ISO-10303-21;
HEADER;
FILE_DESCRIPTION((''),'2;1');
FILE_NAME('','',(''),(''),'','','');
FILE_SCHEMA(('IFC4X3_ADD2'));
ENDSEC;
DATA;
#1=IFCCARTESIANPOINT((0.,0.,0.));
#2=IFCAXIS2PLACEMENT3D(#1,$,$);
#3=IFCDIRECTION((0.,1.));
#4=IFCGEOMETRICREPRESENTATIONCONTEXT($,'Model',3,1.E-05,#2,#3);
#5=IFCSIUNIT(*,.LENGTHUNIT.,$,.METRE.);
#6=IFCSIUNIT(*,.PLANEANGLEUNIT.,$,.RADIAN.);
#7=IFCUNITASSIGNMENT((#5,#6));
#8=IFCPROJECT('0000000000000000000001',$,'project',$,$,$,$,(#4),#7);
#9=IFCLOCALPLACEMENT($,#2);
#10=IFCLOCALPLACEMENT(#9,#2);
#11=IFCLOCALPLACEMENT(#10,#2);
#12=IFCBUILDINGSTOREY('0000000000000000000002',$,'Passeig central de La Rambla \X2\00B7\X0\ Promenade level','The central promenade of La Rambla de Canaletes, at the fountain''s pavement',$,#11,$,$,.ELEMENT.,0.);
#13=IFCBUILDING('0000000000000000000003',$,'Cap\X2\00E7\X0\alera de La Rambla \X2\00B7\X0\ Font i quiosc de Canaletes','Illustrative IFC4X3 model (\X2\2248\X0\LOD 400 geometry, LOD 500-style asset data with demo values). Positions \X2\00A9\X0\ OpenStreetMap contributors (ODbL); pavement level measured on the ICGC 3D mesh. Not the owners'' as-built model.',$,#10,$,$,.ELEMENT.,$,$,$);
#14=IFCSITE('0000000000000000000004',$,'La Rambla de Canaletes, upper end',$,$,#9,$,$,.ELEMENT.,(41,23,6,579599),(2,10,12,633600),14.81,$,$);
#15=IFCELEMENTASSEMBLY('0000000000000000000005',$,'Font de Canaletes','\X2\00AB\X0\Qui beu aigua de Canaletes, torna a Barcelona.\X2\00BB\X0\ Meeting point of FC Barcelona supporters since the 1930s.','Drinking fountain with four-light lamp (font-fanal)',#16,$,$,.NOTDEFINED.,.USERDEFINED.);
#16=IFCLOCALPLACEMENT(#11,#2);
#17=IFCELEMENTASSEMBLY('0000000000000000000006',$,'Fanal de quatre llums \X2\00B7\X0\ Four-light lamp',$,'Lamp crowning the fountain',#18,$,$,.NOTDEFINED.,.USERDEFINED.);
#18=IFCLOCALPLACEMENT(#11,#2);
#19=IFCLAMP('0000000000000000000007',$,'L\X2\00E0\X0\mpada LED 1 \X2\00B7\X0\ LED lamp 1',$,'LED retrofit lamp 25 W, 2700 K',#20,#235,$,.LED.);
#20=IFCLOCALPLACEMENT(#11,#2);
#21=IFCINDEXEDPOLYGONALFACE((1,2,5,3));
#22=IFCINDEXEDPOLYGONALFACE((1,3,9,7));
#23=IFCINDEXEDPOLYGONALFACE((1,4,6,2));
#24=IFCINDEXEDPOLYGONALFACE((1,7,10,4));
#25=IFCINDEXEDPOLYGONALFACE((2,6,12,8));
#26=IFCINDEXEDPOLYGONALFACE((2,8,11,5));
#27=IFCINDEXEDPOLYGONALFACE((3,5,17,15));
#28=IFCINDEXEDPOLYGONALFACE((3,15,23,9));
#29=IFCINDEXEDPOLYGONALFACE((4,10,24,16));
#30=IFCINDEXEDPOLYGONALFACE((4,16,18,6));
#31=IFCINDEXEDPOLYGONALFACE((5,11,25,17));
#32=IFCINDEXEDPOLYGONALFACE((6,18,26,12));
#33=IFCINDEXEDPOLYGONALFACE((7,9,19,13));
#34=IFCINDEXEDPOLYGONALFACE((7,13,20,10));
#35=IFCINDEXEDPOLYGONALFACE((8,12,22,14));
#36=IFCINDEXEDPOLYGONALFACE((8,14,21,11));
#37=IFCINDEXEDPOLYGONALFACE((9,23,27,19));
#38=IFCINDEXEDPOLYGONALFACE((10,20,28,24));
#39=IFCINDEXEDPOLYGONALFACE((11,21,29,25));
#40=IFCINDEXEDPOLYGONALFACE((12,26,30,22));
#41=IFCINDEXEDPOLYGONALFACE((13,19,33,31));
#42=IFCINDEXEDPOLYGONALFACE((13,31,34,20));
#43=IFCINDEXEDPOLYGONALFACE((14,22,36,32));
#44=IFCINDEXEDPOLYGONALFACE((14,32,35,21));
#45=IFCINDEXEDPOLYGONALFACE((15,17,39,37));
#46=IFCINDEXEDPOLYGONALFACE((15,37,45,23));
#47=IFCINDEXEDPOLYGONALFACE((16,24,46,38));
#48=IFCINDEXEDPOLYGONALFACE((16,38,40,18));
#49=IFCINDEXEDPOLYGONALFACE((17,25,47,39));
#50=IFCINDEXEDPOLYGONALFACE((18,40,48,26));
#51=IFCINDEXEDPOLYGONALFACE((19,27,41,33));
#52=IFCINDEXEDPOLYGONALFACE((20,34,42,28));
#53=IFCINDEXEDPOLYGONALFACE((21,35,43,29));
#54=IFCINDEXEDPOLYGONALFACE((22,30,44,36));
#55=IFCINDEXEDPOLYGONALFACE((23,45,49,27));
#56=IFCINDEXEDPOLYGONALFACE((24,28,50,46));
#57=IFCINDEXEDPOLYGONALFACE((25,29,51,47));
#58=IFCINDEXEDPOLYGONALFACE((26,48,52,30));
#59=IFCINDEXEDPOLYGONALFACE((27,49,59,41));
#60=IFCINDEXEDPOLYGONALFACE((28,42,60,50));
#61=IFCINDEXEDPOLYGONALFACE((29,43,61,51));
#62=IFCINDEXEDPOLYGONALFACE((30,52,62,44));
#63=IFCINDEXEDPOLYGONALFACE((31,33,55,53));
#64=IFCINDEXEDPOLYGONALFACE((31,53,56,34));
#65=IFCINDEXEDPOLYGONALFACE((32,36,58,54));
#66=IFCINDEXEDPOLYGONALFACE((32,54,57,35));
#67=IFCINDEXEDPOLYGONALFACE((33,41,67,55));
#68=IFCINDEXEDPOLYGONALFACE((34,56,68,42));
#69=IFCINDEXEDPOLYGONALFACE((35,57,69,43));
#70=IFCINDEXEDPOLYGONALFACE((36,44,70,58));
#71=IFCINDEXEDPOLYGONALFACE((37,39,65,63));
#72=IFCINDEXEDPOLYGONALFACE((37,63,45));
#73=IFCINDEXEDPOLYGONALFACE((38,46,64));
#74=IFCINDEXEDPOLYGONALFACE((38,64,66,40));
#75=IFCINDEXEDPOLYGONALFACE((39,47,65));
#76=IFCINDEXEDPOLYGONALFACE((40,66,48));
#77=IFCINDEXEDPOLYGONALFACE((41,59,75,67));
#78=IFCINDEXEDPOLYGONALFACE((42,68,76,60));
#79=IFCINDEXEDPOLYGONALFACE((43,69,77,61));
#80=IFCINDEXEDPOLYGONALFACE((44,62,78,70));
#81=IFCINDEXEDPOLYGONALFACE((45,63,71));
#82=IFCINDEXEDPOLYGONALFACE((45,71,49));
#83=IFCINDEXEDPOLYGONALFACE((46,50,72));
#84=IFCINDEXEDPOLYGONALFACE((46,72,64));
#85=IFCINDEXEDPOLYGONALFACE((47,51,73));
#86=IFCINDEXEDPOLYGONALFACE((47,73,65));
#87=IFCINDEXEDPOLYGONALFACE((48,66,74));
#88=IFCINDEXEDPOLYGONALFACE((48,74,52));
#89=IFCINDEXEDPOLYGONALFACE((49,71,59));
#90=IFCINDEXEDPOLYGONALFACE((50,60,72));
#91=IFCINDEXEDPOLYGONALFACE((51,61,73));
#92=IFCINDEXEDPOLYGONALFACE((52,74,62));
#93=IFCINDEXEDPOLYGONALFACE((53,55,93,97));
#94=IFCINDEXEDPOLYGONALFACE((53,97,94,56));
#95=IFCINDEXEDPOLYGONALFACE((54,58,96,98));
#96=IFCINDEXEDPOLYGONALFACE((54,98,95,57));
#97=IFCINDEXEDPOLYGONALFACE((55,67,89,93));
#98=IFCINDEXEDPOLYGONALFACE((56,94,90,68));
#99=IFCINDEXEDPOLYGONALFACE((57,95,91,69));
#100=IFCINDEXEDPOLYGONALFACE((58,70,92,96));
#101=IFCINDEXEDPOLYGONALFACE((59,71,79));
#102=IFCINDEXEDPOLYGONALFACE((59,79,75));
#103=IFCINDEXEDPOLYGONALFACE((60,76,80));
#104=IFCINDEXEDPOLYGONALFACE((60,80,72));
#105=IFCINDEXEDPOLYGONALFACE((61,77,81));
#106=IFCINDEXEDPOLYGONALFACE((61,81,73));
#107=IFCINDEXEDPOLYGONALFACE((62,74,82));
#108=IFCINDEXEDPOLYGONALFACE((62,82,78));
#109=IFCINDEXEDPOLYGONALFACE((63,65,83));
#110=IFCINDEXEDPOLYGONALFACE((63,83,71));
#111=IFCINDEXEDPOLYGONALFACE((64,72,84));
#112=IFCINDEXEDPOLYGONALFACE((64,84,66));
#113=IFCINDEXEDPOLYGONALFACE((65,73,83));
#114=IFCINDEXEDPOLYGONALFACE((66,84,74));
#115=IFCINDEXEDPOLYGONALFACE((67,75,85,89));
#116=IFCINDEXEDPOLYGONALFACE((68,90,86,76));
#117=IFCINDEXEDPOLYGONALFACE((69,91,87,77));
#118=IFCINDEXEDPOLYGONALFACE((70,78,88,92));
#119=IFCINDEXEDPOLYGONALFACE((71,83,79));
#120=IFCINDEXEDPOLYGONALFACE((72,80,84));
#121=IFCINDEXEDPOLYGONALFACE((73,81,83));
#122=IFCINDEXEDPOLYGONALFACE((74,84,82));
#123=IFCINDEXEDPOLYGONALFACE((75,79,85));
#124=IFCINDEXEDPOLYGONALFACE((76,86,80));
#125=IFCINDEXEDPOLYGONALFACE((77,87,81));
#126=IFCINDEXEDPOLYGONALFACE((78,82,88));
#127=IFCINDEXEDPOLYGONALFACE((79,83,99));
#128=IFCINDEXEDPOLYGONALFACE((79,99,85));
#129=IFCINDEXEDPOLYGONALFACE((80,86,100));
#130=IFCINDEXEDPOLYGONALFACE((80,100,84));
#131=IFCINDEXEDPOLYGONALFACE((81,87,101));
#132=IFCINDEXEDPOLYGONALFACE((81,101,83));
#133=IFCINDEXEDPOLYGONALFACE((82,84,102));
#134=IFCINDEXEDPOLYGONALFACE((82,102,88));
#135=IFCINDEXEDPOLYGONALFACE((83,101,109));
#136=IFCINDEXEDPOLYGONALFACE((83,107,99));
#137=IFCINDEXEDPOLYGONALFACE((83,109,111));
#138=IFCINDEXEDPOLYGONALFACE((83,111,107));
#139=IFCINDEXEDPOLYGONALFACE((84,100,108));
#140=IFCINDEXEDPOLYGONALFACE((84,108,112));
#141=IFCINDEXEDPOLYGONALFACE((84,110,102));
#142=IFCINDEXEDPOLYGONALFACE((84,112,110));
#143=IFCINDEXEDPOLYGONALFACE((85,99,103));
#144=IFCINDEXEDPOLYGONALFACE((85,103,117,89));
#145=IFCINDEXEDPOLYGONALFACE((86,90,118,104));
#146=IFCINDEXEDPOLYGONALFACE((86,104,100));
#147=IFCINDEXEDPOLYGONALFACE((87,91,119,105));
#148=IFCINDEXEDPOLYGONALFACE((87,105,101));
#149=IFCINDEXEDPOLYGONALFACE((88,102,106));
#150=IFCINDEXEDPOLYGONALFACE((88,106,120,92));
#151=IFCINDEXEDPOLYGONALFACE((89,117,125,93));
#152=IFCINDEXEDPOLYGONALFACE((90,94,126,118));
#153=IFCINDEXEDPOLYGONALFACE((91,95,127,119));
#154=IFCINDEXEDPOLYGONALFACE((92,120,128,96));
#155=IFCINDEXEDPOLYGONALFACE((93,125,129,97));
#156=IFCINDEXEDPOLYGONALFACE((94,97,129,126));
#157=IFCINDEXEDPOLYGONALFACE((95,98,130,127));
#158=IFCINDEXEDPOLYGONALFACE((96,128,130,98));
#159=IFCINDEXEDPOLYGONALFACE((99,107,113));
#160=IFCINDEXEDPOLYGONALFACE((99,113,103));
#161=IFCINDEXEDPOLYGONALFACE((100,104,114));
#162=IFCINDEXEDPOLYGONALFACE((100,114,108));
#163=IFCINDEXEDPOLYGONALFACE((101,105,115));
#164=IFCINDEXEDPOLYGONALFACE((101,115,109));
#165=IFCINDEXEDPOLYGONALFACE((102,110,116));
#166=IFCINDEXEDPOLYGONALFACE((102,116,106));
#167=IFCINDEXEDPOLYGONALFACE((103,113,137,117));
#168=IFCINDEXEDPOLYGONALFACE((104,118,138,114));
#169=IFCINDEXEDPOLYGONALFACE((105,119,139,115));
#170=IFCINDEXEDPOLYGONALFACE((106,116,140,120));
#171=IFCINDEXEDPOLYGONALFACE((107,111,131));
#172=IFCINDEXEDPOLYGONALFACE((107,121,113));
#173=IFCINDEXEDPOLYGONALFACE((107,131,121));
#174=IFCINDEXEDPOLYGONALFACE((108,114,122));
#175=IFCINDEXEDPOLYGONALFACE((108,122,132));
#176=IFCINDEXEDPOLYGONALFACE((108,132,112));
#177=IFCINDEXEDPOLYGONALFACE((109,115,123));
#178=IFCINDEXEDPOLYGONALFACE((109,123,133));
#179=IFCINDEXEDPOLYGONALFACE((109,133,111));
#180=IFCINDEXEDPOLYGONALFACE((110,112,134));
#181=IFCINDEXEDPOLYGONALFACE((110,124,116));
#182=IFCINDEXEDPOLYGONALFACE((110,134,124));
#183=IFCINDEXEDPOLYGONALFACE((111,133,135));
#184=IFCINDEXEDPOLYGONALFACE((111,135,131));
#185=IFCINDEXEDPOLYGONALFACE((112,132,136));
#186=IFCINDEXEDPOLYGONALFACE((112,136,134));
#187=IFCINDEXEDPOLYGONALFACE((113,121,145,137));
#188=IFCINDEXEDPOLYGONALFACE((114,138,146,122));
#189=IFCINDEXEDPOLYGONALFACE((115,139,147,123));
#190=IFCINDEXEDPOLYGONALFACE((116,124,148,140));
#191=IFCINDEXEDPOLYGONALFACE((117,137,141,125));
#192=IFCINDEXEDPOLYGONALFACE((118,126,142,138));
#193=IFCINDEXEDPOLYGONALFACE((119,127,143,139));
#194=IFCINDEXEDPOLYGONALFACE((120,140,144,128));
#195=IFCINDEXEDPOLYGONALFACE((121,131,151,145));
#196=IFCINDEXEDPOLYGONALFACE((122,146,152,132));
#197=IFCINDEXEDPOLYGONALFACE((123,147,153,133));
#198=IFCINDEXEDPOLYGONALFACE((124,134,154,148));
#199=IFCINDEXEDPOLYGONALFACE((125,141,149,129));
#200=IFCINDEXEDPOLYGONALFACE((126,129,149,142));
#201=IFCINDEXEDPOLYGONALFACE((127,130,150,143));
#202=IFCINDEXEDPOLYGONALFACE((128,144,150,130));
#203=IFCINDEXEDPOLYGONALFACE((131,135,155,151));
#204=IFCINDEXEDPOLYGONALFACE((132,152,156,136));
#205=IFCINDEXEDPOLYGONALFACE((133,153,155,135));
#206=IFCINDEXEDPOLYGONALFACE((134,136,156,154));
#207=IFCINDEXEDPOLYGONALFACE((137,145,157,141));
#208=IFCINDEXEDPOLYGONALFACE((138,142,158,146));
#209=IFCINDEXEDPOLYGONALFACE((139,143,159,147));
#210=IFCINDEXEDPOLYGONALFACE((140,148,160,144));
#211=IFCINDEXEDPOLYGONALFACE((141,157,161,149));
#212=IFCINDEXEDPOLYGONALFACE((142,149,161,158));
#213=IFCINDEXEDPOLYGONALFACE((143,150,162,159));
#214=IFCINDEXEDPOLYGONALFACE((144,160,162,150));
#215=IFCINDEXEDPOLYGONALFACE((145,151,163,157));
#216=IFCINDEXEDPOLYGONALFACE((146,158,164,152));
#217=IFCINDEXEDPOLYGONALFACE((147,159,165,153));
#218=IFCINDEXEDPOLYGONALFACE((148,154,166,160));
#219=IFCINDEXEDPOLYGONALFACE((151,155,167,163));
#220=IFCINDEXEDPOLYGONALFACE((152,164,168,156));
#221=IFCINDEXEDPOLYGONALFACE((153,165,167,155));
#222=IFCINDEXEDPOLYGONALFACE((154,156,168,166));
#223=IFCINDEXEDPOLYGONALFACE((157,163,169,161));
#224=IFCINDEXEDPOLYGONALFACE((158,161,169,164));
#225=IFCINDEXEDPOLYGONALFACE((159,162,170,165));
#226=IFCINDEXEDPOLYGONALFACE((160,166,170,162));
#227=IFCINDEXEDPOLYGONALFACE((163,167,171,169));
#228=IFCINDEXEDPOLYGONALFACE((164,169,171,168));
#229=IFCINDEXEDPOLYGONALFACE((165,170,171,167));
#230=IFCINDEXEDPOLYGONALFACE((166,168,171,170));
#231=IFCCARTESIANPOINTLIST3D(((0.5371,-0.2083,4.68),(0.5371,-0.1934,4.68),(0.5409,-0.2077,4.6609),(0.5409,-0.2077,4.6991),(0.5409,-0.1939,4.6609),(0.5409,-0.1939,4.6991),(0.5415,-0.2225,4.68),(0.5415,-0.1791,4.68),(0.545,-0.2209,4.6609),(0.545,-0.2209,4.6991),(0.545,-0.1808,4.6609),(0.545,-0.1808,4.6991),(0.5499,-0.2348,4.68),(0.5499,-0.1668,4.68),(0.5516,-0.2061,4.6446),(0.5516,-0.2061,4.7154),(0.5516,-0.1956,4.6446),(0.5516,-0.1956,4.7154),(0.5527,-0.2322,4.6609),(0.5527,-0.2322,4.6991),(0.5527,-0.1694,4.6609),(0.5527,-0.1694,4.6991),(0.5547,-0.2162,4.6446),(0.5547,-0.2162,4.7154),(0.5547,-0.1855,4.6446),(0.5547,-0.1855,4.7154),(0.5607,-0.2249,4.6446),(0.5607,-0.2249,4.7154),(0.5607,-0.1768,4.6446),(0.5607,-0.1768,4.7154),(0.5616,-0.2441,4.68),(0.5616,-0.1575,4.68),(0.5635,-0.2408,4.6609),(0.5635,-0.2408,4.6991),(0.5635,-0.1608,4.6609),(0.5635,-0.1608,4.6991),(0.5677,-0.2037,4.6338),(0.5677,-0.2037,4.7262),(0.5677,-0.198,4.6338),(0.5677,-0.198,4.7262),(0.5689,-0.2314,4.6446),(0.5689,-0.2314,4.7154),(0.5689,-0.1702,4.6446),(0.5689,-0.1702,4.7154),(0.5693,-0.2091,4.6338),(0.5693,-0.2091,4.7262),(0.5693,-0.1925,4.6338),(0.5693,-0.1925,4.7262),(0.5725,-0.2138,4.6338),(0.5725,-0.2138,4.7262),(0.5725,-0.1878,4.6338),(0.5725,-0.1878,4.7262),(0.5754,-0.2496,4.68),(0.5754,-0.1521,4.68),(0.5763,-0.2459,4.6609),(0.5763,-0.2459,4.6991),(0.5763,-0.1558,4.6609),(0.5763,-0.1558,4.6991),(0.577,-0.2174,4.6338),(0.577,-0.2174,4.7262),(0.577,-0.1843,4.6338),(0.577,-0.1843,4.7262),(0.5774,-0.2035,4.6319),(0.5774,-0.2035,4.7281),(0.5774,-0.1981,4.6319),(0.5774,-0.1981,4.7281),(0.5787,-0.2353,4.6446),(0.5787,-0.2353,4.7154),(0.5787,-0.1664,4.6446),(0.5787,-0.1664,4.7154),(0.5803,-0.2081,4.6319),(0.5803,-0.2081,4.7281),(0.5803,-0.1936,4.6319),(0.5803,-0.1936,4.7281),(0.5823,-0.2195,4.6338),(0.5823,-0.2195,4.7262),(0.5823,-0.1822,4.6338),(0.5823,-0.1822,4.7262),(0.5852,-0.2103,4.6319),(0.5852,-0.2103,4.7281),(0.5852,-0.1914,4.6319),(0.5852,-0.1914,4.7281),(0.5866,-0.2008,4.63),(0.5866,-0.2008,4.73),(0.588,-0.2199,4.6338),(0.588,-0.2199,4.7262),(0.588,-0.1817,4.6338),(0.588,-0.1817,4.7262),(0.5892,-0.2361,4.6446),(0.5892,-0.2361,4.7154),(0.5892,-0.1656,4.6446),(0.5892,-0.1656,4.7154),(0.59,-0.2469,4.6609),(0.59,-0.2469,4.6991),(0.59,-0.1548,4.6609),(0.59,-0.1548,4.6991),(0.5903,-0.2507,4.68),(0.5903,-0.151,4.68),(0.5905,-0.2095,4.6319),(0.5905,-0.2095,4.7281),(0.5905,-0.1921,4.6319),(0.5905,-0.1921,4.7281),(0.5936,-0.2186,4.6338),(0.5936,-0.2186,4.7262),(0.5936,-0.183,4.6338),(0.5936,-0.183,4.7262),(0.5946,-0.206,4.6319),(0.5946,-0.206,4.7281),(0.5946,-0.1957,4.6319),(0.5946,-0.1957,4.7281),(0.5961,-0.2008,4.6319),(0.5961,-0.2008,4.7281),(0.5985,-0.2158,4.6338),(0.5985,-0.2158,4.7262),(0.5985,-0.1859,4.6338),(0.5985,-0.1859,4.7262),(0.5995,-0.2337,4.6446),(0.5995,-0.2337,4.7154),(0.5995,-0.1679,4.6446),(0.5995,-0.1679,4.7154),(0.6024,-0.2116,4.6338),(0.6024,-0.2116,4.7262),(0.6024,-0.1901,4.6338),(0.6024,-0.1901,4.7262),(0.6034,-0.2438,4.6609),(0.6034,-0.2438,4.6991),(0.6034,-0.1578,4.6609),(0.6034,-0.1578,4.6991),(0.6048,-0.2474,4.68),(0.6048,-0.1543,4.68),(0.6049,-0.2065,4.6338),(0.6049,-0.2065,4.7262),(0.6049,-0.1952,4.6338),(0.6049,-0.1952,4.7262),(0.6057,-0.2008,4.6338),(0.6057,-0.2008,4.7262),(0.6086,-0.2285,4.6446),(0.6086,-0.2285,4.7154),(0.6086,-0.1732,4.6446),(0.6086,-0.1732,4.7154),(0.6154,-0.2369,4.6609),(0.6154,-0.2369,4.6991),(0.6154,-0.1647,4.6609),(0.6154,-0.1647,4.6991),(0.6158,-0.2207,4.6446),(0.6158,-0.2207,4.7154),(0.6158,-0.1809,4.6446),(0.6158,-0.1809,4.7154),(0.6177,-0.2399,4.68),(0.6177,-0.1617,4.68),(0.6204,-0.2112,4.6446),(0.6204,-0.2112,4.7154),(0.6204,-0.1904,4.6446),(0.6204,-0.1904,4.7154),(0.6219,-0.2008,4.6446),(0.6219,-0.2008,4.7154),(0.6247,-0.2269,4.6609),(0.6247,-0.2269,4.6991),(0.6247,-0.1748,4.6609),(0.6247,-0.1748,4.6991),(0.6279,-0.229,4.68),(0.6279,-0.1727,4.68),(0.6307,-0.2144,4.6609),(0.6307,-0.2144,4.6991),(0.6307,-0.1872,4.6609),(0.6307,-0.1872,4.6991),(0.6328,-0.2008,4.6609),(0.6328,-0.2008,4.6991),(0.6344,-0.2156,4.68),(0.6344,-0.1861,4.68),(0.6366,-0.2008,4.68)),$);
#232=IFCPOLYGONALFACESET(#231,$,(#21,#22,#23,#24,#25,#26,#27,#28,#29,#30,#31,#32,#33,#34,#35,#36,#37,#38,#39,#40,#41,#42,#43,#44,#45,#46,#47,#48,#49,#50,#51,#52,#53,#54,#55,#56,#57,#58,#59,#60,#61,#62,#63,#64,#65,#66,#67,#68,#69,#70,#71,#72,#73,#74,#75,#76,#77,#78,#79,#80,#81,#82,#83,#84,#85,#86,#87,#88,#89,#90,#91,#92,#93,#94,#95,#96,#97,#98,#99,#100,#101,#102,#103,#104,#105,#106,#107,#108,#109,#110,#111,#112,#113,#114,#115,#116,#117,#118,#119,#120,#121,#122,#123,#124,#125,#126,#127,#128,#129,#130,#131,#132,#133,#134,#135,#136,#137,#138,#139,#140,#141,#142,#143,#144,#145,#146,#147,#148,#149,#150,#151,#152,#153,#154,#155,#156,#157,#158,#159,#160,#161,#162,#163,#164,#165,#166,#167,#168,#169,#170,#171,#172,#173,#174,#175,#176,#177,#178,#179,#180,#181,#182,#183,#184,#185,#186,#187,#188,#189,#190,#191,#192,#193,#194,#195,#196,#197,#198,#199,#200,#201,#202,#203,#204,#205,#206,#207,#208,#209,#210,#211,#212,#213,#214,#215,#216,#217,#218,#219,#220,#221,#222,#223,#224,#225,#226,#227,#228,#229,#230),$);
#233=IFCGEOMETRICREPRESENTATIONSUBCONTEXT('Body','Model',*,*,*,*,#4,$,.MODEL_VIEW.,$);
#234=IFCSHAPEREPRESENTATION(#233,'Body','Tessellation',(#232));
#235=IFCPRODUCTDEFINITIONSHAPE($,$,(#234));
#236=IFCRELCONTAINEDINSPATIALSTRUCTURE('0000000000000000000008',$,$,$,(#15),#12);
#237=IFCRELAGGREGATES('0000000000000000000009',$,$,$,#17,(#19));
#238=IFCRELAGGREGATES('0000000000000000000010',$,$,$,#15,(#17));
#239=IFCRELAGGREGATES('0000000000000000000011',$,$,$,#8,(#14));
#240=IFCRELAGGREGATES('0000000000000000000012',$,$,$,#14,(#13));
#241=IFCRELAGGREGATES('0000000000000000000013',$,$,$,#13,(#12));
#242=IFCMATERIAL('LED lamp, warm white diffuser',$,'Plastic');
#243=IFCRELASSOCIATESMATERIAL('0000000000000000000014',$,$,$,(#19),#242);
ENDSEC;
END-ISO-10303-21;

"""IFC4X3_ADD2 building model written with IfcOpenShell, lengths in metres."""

from ifc_helpers import new_model, entity, si_unit, direction, origin, place, context, subcontext, project, spatial, material, element, aggregate, save


model = new_model("IFC4X3_ADD2")

# Units and contexts
model_context = context("Model", 3, precision=1e-05, world=origin(), true_north=direction((0.0, 1.0)))
body_context = subcontext(model_context, "Body", "Model", "MODEL_VIEW")
ifc_project = project(units=[si_unit("LENGTHUNIT", "METRE"), si_unit("PLANEANGLEUNIT", "RADIAN")], contexts=[model_context])

# Site, building, storey
site_placement = place(None, origin())
site = spatial("IfcSite", under=ifc_project, at=site_placement, Name="La Rambla de Canaletes, upper end", CompositionType="ELEMENT", RefLatitude=(41, 23, 6, 579599), RefLongitude=(2, 10, 12, 633600), RefElevation=14.81)
building_placement = place(site_placement, origin())
building = spatial("IfcBuilding", under=site, at=building_placement, Name="Capçalera de La Rambla · Font i quiosc de Canaletes", Description="Illustrative IFC4X3 model (≈LOD 400 geometry, LOD 500-style asset data with demo values). Positions © OpenStreetMap contributors (ODbL); pavement level measured on the ICGC 3D mesh. Not the owners' as-built model.", CompositionType="ELEMENT")
storey_placement = place(building_placement, origin())
storey = spatial("IfcBuildingStorey", under=building, at=storey_placement, Name="Passeig central de La Rambla · Promenade level", Description="The central promenade of La Rambla de Canaletes, at the fountain's pavement", CompositionType="ELEMENT", Elevation=0.0)

# Element assemblies, lamp
assembly_1_placement = place(building_placement, origin())
assembly_1 = element("IfcElementAssembly", 1, at=assembly_1_placement, inside=storey, Name="Font de Canaletes", Description="«Qui beu aigua de Canaletes, torna a Barcelona.» Meeting point of FC Barcelona supporters since the 1930s.", ObjectType="Drinking fountain with four-light lamp (font-fanal)", AssemblyPlace="NOTDEFINED", PredefinedType="USERDEFINED")
assembly_2_placement = place(building_placement, origin())
assembly_2 = element("IfcElementAssembly", 2, at=assembly_2_placement, Name="Fanal de quatre llums · Four-light lamp", ObjectType="Lamp crowning the fountain", AssemblyPlace="NOTDEFINED", PredefinedType="USERDEFINED")
ifc_material_1 = material(Name="LED lamp, warm white diffuser", Category="Plastic")
lamp_1_placement = place(building_placement, origin())
lamp_1 = element("IfcLamp", 3, at=lamp_1_placement, material=ifc_material_1, Name="Làmpada LED 1 · LED lamp 1", ObjectType="LED retrofit lamp 25 W, 2700 K", PredefinedType="LED", context=body_context, shape_type="SweptSolid", body=[
    entity("IfcRevolvedAreaSolid", entity("IfcArbitraryClosedProfileDef", "AREA", None, entity("IfcPolyline", [entity("IfcCartesianPoint", [0.0, -0.05]), entity("IfcCartesianPoint", [0.0191, -0.0462]), entity("IfcCartesianPoint", [0.0354, -0.0354]), entity("IfcCartesianPoint", [0.0462, -0.0191]), entity("IfcCartesianPoint", [0.05, 0.0]), entity("IfcCartesianPoint", [0.0462, 0.0191]), entity("IfcCartesianPoint", [0.0354, 0.0354]), entity("IfcCartesianPoint", [0.0191, 0.0462]), entity("IfcCartesianPoint", [0.0, 0.05]), entity("IfcCartesianPoint", [0.0, -0.05])])), entity("IfcAxis2Placement3D", entity("IfcCartesianPoint", [0.5866, -0.2008, 4.68]), entity("IfcDirection", [0.0, -1.0, 0.0]), entity("IfcDirection", [1.0, 0.0, 0.0])), entity("IfcAxis1Placement", entity("IfcCartesianPoint", [0.0, 0.0, 0.0]), entity("IfcDirection", [0.0, 1.0, 0.0])), 6.283185),
])
aggregate(assembly_2, [lamp_1])
aggregate(assembly_1, [assembly_2])

save(model, "model.ifc")
